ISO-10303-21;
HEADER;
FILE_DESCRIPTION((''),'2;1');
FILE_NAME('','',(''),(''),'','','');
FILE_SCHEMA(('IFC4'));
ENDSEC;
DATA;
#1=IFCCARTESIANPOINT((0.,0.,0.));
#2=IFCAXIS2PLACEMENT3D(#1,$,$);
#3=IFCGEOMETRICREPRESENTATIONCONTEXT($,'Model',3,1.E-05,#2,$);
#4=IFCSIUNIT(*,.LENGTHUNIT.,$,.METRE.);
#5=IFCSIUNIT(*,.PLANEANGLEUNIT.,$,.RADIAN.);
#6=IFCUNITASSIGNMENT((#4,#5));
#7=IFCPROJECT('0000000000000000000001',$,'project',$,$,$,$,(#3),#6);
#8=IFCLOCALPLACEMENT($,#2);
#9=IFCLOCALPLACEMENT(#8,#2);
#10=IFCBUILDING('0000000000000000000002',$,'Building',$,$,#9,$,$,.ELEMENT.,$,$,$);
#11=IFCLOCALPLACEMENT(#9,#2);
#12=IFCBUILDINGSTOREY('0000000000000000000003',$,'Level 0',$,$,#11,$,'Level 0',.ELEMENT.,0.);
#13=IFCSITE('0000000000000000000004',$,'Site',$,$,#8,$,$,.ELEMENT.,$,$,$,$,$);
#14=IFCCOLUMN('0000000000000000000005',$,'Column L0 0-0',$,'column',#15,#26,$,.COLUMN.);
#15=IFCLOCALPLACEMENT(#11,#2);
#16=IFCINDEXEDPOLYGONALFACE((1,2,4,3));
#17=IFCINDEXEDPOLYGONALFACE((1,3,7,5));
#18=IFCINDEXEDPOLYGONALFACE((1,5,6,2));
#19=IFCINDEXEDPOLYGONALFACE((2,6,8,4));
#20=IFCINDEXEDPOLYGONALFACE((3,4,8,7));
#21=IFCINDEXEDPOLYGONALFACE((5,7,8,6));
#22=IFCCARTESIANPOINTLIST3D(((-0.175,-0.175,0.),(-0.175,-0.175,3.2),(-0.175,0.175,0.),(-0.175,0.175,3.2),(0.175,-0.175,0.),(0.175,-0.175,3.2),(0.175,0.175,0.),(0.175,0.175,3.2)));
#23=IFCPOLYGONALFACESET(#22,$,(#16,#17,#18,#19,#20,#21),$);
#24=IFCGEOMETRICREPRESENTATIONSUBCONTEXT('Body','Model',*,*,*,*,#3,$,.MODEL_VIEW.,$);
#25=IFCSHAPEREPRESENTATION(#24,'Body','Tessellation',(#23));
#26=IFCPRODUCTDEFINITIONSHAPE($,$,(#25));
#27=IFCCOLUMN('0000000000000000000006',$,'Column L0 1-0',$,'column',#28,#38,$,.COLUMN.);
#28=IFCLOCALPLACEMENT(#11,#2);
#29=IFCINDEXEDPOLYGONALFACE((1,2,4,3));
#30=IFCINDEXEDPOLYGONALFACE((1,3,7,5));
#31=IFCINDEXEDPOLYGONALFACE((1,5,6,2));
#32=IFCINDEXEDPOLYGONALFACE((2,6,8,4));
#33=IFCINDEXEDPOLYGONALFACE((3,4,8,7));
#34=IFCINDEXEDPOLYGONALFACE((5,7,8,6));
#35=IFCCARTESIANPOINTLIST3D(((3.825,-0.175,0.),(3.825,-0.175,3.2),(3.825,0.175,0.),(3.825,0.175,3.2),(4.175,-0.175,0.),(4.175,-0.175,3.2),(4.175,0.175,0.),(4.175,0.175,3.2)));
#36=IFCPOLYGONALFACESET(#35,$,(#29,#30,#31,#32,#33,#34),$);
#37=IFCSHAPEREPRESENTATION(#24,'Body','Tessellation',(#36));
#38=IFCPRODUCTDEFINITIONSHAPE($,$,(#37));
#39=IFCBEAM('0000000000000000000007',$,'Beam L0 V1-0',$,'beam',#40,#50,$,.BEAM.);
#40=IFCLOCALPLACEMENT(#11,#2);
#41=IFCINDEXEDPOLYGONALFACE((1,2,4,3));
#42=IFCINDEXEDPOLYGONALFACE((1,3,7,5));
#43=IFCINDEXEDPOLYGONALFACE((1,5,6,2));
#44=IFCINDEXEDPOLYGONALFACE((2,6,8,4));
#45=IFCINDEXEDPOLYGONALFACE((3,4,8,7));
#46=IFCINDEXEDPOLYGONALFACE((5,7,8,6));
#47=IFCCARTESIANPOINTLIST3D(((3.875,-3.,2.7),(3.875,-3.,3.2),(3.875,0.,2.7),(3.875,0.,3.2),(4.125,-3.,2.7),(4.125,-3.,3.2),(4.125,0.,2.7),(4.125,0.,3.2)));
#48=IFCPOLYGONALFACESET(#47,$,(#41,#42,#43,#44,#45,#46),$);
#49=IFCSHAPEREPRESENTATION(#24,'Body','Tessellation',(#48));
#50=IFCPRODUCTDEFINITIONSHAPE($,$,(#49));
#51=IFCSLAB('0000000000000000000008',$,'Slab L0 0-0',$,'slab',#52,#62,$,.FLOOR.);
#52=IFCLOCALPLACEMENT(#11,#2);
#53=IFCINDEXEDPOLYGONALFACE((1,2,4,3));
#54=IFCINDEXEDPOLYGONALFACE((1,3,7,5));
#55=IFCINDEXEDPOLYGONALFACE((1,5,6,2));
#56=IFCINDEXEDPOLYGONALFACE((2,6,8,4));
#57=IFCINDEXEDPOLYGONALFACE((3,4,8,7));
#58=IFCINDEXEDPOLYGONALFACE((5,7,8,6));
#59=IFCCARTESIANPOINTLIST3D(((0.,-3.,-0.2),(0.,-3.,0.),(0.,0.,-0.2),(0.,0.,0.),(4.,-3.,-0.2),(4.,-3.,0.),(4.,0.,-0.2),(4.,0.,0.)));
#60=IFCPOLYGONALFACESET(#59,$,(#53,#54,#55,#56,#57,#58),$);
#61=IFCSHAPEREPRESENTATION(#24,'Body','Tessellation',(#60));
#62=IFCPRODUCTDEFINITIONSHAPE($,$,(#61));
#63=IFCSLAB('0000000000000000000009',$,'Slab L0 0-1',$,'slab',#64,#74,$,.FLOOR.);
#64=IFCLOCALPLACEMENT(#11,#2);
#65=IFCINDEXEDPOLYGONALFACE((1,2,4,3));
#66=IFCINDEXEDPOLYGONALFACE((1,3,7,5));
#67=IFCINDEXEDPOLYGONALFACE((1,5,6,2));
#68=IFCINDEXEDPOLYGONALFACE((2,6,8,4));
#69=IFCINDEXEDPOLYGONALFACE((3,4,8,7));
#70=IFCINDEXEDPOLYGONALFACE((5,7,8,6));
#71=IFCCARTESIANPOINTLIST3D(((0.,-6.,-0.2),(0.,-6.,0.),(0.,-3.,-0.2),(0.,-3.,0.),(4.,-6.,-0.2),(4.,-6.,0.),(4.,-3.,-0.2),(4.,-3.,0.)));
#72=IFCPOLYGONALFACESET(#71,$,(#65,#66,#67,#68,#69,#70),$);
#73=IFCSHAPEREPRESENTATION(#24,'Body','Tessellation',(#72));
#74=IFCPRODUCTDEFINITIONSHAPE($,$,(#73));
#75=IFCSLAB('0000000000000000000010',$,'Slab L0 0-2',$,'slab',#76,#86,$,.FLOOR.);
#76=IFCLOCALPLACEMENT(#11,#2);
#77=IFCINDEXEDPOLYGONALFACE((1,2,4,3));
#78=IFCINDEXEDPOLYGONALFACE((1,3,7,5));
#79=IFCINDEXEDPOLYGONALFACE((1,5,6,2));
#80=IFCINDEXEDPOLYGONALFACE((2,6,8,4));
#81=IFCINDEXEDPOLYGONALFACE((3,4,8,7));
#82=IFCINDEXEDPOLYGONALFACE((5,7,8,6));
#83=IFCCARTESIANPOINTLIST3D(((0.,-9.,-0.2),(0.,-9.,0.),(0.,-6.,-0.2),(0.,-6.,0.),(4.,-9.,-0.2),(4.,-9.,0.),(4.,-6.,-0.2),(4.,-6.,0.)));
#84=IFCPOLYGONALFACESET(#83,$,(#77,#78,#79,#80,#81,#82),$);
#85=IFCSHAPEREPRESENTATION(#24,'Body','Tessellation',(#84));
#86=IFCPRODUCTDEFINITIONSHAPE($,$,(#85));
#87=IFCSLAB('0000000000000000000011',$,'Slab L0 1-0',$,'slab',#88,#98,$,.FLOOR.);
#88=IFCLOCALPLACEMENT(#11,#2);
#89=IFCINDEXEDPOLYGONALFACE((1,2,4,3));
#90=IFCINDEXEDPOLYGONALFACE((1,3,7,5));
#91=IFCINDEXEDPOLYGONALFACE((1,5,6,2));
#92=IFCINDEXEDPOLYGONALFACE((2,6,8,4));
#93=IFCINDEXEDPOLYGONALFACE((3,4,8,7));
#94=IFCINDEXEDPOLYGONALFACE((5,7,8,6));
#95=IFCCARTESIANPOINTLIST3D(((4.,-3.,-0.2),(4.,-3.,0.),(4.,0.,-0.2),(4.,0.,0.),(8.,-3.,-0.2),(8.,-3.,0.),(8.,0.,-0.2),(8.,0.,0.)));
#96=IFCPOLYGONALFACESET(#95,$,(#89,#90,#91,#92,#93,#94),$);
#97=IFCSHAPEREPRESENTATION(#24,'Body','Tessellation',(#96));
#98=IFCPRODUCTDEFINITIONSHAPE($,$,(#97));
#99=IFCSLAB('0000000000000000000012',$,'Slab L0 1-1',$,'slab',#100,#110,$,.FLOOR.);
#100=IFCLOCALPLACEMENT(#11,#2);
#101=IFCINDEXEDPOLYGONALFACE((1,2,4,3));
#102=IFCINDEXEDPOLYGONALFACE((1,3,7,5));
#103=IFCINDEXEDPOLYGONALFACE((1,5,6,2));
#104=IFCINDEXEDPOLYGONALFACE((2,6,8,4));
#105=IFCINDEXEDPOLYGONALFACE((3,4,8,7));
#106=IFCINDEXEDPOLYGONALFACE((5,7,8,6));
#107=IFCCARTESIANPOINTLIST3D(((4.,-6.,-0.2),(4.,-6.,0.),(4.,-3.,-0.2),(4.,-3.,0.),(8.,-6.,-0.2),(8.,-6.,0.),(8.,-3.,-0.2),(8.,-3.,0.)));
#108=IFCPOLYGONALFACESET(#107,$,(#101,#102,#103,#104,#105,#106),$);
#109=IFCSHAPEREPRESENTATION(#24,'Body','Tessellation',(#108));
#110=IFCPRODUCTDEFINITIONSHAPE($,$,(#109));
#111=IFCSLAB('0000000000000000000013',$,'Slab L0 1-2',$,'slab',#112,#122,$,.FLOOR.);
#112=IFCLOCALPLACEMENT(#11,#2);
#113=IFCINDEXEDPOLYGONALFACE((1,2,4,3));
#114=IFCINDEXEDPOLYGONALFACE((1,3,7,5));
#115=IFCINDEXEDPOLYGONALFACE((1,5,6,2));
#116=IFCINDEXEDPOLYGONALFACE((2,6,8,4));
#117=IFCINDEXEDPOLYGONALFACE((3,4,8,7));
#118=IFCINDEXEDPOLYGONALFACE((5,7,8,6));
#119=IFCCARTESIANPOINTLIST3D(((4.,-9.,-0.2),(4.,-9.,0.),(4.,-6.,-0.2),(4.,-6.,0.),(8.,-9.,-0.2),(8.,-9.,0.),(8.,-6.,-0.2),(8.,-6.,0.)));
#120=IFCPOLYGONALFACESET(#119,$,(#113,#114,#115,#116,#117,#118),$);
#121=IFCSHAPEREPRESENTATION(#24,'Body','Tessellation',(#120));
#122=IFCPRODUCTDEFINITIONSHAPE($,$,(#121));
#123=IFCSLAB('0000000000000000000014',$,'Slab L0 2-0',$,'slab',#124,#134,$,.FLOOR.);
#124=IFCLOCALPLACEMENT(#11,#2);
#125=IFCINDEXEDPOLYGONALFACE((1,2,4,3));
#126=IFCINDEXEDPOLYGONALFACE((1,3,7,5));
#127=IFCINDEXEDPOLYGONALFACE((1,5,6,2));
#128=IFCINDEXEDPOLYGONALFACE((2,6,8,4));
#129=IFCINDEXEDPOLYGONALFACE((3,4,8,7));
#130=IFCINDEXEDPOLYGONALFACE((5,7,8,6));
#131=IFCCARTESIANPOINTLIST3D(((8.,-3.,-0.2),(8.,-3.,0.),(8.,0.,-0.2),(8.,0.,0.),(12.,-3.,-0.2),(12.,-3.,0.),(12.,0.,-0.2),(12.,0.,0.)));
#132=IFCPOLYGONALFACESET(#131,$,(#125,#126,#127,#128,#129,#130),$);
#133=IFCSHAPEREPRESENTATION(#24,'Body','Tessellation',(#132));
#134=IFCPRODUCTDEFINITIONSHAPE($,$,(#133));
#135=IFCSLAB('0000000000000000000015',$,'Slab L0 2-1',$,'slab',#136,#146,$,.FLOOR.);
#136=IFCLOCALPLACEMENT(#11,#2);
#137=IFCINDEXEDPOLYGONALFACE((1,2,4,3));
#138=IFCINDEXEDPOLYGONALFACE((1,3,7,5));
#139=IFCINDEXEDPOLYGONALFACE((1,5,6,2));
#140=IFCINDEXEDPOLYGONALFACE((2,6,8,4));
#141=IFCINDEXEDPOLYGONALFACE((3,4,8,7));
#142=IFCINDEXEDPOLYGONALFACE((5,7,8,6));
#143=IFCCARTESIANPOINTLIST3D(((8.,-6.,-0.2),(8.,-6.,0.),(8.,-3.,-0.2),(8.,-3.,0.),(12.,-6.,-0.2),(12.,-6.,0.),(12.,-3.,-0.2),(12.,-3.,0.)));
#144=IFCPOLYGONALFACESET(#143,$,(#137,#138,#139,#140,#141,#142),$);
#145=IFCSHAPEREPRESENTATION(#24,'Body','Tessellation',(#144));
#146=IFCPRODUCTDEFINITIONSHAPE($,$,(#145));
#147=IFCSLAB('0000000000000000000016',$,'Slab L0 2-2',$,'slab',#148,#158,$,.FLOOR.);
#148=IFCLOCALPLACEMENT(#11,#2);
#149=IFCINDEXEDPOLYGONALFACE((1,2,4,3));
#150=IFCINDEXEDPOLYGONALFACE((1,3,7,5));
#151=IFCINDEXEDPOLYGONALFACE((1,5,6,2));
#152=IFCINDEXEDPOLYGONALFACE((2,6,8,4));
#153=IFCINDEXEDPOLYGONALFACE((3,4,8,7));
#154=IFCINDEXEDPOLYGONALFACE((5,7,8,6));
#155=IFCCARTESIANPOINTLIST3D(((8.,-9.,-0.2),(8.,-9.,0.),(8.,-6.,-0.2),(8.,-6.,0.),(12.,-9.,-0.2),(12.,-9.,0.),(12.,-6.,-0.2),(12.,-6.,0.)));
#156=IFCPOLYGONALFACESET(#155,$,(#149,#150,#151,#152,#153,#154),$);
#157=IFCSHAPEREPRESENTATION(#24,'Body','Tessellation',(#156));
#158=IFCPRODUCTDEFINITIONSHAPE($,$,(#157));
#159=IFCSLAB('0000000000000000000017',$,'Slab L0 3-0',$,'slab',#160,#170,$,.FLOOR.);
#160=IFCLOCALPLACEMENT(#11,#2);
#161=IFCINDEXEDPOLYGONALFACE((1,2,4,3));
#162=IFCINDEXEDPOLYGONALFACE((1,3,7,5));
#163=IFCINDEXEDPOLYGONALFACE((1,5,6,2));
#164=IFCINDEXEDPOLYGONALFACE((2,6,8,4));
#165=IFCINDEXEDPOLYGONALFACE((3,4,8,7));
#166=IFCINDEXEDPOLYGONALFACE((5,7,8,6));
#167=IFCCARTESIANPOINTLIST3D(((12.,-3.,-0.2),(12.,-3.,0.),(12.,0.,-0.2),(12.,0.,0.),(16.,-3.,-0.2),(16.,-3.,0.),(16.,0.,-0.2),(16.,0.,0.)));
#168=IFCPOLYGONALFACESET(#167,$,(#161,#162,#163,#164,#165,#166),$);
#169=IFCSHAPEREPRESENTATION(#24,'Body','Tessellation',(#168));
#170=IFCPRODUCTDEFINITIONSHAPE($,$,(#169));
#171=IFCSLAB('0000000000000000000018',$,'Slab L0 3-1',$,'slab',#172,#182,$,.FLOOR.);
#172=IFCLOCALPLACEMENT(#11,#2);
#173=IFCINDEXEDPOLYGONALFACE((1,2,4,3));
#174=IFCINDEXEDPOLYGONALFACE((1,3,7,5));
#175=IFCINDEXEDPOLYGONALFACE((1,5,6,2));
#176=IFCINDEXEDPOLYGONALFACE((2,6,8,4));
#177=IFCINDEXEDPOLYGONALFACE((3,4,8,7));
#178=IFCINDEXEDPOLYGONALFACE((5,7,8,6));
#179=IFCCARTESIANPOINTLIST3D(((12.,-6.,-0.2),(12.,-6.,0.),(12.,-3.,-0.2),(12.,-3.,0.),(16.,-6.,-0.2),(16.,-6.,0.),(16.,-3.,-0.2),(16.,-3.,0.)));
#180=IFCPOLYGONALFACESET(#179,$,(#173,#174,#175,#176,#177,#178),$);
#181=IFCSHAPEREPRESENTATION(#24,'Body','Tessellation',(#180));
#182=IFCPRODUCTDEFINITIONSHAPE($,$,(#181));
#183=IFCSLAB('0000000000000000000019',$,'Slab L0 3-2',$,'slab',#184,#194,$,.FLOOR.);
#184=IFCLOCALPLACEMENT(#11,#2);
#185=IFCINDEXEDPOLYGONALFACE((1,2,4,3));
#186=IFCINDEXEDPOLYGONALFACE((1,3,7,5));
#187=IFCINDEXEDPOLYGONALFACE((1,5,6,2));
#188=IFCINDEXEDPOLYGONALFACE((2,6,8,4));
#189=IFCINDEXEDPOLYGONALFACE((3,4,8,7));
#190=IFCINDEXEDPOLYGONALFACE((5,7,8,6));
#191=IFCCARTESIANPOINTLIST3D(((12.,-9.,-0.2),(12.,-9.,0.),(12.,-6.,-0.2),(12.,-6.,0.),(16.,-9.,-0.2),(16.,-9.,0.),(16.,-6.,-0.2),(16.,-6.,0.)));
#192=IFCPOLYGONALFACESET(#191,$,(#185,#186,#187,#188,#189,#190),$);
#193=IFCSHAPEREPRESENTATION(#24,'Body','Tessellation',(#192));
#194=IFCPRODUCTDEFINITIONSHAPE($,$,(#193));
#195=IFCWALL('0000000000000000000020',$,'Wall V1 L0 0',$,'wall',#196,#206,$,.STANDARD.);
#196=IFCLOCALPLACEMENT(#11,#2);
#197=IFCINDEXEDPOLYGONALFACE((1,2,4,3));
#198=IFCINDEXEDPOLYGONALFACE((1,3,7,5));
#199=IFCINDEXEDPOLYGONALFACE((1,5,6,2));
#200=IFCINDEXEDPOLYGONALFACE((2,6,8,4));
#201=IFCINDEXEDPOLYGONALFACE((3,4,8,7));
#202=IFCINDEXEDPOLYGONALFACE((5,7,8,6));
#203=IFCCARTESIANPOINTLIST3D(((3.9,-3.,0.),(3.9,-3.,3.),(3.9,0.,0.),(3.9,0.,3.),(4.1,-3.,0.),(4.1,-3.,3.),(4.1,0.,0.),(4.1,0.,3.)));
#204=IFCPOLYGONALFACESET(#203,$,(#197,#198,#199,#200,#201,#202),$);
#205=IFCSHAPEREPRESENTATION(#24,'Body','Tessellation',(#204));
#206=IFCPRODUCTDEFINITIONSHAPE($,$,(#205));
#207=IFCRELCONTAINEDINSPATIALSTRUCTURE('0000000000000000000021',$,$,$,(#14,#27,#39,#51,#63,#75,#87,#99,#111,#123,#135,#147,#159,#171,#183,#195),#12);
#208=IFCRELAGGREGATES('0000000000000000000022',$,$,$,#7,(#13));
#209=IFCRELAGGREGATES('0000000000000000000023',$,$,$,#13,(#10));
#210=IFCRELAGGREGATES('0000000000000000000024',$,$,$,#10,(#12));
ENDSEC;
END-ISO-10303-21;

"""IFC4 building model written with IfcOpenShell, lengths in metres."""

from ifc_helpers import new_model, si_unit, frame, frame_2d, origin, origin_2d, place, context, subcontext, project, spatial, polyline, rectangle, outline, extrude, element, save


model = new_model("IFC4")

# Units and contexts
model_context = context("Model", 3, precision=1e-05, world=origin())
body_context = subcontext(model_context, "Body", "Model", "MODEL_VIEW")
ifc_project = project(units=[si_unit("LENGTHUNIT", "METRE"), si_unit("PLANEANGLEUNIT", "RADIAN")], contexts=[model_context])

# Site, building, storey
site_placement = place(None, origin())
site = spatial("IfcSite", under=ifc_project, at=site_placement, Name="Site", CompositionType="ELEMENT")
building_placement = place(site_placement, origin())
building = spatial("IfcBuilding", under=site, at=building_placement, Name="Building", CompositionType="ELEMENT")
storey_placement = place(building_placement, origin())
storey = spatial("IfcBuildingStorey", under=building, at=storey_placement, Name="Level 0", LongName="Level 0", CompositionType="ELEMENT", Elevation=0.0)

# Columns
for number, where, name in (
    (1, (0.0, 0.0, 0.0), "Column L0 0-0"),
    (2, (4.0, 0.0, 0.0), "Column L0 1-0"),
):
    element("IfcColumn", number, at=place(storey_placement, frame(where)), inside=storey, Name=name, ObjectType="column", PredefinedType="COLUMN", context=body_context, shape_type="SweptSolid", body=[
        extrude(rectangle(XDim=0.35, YDim=0.35, at=origin_2d()), origin(), (0.0, 0.0, 1.0), 3.2),
    ])

# Beam
beam_placement = place(storey_placement, frame((4.0, 0.0, 2.95), z_axis=(0.0, -1.0, 0.0), x_axis=(0.0, 0.0, 1.0)))
element("IfcBeam", 3, at=beam_placement, inside=storey, Name="Beam L0 V1-0", ObjectType="beam", PredefinedType="BEAM", context=body_context, shape_type="SweptSolid", body=[
    extrude(rectangle(XDim=0.5, YDim=0.25, at=origin_2d()), origin(), (0.0, 0.0, 1.0), 3.0),
])

# Slabs
slab_1_placement = place(storey_placement, frame((0.0, 0.0, -0.2)))
element("IfcSlab", 4, at=slab_1_placement, inside=storey, Name="Slab L0 0-0", ObjectType="slab", PredefinedType="FLOOR", context=body_context, shape_type="SweptSolid", body=[
    extrude(outline(polyline([(0.0, -3.0), (4.0, -3.0), (4.0, 0.0), (0.0, 0.0), (0.0, -3.0)])), origin(), (0.0, 0.0, 1.0), 0.2),
])
slab_2_placement = place(storey_placement, frame((0.0, 0.0, -0.2)))
element("IfcSlab", 5, at=slab_2_placement, inside=storey, Name="Slab L0 0-1", ObjectType="slab", PredefinedType="FLOOR", context=body_context, shape_type="SweptSolid", body=[
    extrude(outline(polyline([(0.0, -6.0), (4.0, -6.0), (4.0, -3.0), (0.0, -3.0), (0.0, -6.0)])), origin(), (0.0, 0.0, 1.0), 0.2),
])
slab_3_placement = place(storey_placement, frame((0.0, 0.0, -0.2)))
element("IfcSlab", 6, at=slab_3_placement, inside=storey, Name="Slab L0 0-2", ObjectType="slab", PredefinedType="FLOOR", context=body_context, shape_type="SweptSolid", body=[
    extrude(outline(polyline([(0.0, -9.0), (4.0, -9.0), (4.0, -6.0), (0.0, -6.0), (0.0, -9.0)])), origin(), (0.0, 0.0, 1.0), 0.2),
])
slab_4_placement = place(storey_placement, frame((0.0, 0.0, -0.2)))
element("IfcSlab", 7, at=slab_4_placement, inside=storey, Name="Slab L0 1-0", ObjectType="slab", PredefinedType="FLOOR", context=body_context, shape_type="SweptSolid", body=[
    extrude(outline(polyline([(4.0, -3.0), (8.0, -3.0), (8.0, 0.0), (4.0, 0.0), (4.0, -3.0)])), origin(), (0.0, 0.0, 1.0), 0.2),
])
slab_5_placement = place(storey_placement, frame((0.0, 0.0, -0.2)))
element("IfcSlab", 8, at=slab_5_placement, inside=storey, Name="Slab L0 1-1", ObjectType="slab", PredefinedType="FLOOR", context=body_context, shape_type="SweptSolid", body=[
    extrude(outline(polyline([(4.0, -6.0), (8.0, -6.0), (8.0, -3.0), (4.0, -3.0), (4.0, -6.0)])), origin(), (0.0, 0.0, 1.0), 0.2),
])
slab_6_placement = place(storey_placement, frame((0.0, 0.0, -0.2)))
element("IfcSlab", 9, at=slab_6_placement, inside=storey, Name="Slab L0 1-2", ObjectType="slab", PredefinedType="FLOOR", context=body_context, shape_type="SweptSolid", body=[
    extrude(outline(polyline([(4.0, -9.0), (8.0, -9.0), (8.0, -6.0), (4.0, -6.0), (4.0, -9.0)])), origin(), (0.0, 0.0, 1.0), 0.2),
])
slab_7_placement = place(storey_placement, frame((0.0, 0.0, -0.2)))
element("IfcSlab", 10, at=slab_7_placement, inside=storey, Name="Slab L0 2-0", ObjectType="slab", PredefinedType="FLOOR", context=body_context, shape_type="SweptSolid", body=[
    extrude(outline(polyline([(8.0, -3.0), (12.0, -3.0), (12.0, 0.0), (8.0, 0.0), (8.0, -3.0)])), origin(), (0.0, 0.0, 1.0), 0.2),
])
slab_8_placement = place(storey_placement, frame((0.0, 0.0, -0.2)))
element("IfcSlab", 11, at=slab_8_placement, inside=storey, Name="Slab L0 2-1", ObjectType="slab", PredefinedType="FLOOR", context=body_context, shape_type="SweptSolid", body=[
    extrude(outline(polyline([(8.0, -6.0), (12.0, -6.0), (12.0, -3.0), (8.0, -3.0), (8.0, -6.0)])), origin(), (0.0, 0.0, 1.0), 0.2),
])
slab_9_placement = place(storey_placement, frame((0.0, 0.0, -0.2)))
element("IfcSlab", 12, at=slab_9_placement, inside=storey, Name="Slab L0 2-2", ObjectType="slab", PredefinedType="FLOOR", context=body_context, shape_type="SweptSolid", body=[
    extrude(outline(polyline([(8.0, -9.0), (12.0, -9.0), (12.0, -6.0), (8.0, -6.0), (8.0, -9.0)])), origin(), (0.0, 0.0, 1.0), 0.2),
])
slab_10_placement = place(storey_placement, frame((0.0, 0.0, -0.2)))
element("IfcSlab", 13, at=slab_10_placement, inside=storey, Name="Slab L0 3-0", ObjectType="slab", PredefinedType="FLOOR", context=body_context, shape_type="SweptSolid", body=[
    extrude(outline(polyline([(12.0, -3.0), (16.0, -3.0), (16.0, 0.0), (12.0, 0.0), (12.0, -3.0)])), origin(), (0.0, 0.0, 1.0), 0.2),
])
slab_11_placement = place(storey_placement, frame((0.0, 0.0, -0.2)))
element("IfcSlab", 14, at=slab_11_placement, inside=storey, Name="Slab L0 3-1", ObjectType="slab", PredefinedType="FLOOR", context=body_context, shape_type="SweptSolid", body=[
    extrude(outline(polyline([(12.0, -6.0), (16.0, -6.0), (16.0, -3.0), (12.0, -3.0), (12.0, -6.0)])), origin(), (0.0, 0.0, 1.0), 0.2),
])
slab_12_placement = place(storey_placement, frame((0.0, 0.0, -0.2)))
element("IfcSlab", 15, at=slab_12_placement, inside=storey, Name="Slab L0 3-2", ObjectType="slab", PredefinedType="FLOOR", context=body_context, shape_type="SweptSolid", body=[
    extrude(outline(polyline([(12.0, -9.0), (16.0, -9.0), (16.0, -6.0), (12.0, -6.0), (12.0, -9.0)])), origin(), (0.0, 0.0, 1.0), 0.2),
])

# Wall
wall_1_placement = place(storey_placement, frame((4.0, 0.0, 0.0), z_axis=(0.0, 0.0, 1.0), x_axis=(0.0, -1.0, 0.0)))
element("IfcWall", 16, at=wall_1_placement, inside=storey, Name="Wall V1 L0 0", ObjectType="wall", PredefinedType="STANDARD", context=body_context, shape_type="SweptSolid", body=[
    extrude(rectangle(XDim=3.0, YDim=0.2, at=frame_2d((1.5, 0.0))), origin(), (0.0, 0.0, 1.0), 3.0),
])

save(model, "model.ifc")
